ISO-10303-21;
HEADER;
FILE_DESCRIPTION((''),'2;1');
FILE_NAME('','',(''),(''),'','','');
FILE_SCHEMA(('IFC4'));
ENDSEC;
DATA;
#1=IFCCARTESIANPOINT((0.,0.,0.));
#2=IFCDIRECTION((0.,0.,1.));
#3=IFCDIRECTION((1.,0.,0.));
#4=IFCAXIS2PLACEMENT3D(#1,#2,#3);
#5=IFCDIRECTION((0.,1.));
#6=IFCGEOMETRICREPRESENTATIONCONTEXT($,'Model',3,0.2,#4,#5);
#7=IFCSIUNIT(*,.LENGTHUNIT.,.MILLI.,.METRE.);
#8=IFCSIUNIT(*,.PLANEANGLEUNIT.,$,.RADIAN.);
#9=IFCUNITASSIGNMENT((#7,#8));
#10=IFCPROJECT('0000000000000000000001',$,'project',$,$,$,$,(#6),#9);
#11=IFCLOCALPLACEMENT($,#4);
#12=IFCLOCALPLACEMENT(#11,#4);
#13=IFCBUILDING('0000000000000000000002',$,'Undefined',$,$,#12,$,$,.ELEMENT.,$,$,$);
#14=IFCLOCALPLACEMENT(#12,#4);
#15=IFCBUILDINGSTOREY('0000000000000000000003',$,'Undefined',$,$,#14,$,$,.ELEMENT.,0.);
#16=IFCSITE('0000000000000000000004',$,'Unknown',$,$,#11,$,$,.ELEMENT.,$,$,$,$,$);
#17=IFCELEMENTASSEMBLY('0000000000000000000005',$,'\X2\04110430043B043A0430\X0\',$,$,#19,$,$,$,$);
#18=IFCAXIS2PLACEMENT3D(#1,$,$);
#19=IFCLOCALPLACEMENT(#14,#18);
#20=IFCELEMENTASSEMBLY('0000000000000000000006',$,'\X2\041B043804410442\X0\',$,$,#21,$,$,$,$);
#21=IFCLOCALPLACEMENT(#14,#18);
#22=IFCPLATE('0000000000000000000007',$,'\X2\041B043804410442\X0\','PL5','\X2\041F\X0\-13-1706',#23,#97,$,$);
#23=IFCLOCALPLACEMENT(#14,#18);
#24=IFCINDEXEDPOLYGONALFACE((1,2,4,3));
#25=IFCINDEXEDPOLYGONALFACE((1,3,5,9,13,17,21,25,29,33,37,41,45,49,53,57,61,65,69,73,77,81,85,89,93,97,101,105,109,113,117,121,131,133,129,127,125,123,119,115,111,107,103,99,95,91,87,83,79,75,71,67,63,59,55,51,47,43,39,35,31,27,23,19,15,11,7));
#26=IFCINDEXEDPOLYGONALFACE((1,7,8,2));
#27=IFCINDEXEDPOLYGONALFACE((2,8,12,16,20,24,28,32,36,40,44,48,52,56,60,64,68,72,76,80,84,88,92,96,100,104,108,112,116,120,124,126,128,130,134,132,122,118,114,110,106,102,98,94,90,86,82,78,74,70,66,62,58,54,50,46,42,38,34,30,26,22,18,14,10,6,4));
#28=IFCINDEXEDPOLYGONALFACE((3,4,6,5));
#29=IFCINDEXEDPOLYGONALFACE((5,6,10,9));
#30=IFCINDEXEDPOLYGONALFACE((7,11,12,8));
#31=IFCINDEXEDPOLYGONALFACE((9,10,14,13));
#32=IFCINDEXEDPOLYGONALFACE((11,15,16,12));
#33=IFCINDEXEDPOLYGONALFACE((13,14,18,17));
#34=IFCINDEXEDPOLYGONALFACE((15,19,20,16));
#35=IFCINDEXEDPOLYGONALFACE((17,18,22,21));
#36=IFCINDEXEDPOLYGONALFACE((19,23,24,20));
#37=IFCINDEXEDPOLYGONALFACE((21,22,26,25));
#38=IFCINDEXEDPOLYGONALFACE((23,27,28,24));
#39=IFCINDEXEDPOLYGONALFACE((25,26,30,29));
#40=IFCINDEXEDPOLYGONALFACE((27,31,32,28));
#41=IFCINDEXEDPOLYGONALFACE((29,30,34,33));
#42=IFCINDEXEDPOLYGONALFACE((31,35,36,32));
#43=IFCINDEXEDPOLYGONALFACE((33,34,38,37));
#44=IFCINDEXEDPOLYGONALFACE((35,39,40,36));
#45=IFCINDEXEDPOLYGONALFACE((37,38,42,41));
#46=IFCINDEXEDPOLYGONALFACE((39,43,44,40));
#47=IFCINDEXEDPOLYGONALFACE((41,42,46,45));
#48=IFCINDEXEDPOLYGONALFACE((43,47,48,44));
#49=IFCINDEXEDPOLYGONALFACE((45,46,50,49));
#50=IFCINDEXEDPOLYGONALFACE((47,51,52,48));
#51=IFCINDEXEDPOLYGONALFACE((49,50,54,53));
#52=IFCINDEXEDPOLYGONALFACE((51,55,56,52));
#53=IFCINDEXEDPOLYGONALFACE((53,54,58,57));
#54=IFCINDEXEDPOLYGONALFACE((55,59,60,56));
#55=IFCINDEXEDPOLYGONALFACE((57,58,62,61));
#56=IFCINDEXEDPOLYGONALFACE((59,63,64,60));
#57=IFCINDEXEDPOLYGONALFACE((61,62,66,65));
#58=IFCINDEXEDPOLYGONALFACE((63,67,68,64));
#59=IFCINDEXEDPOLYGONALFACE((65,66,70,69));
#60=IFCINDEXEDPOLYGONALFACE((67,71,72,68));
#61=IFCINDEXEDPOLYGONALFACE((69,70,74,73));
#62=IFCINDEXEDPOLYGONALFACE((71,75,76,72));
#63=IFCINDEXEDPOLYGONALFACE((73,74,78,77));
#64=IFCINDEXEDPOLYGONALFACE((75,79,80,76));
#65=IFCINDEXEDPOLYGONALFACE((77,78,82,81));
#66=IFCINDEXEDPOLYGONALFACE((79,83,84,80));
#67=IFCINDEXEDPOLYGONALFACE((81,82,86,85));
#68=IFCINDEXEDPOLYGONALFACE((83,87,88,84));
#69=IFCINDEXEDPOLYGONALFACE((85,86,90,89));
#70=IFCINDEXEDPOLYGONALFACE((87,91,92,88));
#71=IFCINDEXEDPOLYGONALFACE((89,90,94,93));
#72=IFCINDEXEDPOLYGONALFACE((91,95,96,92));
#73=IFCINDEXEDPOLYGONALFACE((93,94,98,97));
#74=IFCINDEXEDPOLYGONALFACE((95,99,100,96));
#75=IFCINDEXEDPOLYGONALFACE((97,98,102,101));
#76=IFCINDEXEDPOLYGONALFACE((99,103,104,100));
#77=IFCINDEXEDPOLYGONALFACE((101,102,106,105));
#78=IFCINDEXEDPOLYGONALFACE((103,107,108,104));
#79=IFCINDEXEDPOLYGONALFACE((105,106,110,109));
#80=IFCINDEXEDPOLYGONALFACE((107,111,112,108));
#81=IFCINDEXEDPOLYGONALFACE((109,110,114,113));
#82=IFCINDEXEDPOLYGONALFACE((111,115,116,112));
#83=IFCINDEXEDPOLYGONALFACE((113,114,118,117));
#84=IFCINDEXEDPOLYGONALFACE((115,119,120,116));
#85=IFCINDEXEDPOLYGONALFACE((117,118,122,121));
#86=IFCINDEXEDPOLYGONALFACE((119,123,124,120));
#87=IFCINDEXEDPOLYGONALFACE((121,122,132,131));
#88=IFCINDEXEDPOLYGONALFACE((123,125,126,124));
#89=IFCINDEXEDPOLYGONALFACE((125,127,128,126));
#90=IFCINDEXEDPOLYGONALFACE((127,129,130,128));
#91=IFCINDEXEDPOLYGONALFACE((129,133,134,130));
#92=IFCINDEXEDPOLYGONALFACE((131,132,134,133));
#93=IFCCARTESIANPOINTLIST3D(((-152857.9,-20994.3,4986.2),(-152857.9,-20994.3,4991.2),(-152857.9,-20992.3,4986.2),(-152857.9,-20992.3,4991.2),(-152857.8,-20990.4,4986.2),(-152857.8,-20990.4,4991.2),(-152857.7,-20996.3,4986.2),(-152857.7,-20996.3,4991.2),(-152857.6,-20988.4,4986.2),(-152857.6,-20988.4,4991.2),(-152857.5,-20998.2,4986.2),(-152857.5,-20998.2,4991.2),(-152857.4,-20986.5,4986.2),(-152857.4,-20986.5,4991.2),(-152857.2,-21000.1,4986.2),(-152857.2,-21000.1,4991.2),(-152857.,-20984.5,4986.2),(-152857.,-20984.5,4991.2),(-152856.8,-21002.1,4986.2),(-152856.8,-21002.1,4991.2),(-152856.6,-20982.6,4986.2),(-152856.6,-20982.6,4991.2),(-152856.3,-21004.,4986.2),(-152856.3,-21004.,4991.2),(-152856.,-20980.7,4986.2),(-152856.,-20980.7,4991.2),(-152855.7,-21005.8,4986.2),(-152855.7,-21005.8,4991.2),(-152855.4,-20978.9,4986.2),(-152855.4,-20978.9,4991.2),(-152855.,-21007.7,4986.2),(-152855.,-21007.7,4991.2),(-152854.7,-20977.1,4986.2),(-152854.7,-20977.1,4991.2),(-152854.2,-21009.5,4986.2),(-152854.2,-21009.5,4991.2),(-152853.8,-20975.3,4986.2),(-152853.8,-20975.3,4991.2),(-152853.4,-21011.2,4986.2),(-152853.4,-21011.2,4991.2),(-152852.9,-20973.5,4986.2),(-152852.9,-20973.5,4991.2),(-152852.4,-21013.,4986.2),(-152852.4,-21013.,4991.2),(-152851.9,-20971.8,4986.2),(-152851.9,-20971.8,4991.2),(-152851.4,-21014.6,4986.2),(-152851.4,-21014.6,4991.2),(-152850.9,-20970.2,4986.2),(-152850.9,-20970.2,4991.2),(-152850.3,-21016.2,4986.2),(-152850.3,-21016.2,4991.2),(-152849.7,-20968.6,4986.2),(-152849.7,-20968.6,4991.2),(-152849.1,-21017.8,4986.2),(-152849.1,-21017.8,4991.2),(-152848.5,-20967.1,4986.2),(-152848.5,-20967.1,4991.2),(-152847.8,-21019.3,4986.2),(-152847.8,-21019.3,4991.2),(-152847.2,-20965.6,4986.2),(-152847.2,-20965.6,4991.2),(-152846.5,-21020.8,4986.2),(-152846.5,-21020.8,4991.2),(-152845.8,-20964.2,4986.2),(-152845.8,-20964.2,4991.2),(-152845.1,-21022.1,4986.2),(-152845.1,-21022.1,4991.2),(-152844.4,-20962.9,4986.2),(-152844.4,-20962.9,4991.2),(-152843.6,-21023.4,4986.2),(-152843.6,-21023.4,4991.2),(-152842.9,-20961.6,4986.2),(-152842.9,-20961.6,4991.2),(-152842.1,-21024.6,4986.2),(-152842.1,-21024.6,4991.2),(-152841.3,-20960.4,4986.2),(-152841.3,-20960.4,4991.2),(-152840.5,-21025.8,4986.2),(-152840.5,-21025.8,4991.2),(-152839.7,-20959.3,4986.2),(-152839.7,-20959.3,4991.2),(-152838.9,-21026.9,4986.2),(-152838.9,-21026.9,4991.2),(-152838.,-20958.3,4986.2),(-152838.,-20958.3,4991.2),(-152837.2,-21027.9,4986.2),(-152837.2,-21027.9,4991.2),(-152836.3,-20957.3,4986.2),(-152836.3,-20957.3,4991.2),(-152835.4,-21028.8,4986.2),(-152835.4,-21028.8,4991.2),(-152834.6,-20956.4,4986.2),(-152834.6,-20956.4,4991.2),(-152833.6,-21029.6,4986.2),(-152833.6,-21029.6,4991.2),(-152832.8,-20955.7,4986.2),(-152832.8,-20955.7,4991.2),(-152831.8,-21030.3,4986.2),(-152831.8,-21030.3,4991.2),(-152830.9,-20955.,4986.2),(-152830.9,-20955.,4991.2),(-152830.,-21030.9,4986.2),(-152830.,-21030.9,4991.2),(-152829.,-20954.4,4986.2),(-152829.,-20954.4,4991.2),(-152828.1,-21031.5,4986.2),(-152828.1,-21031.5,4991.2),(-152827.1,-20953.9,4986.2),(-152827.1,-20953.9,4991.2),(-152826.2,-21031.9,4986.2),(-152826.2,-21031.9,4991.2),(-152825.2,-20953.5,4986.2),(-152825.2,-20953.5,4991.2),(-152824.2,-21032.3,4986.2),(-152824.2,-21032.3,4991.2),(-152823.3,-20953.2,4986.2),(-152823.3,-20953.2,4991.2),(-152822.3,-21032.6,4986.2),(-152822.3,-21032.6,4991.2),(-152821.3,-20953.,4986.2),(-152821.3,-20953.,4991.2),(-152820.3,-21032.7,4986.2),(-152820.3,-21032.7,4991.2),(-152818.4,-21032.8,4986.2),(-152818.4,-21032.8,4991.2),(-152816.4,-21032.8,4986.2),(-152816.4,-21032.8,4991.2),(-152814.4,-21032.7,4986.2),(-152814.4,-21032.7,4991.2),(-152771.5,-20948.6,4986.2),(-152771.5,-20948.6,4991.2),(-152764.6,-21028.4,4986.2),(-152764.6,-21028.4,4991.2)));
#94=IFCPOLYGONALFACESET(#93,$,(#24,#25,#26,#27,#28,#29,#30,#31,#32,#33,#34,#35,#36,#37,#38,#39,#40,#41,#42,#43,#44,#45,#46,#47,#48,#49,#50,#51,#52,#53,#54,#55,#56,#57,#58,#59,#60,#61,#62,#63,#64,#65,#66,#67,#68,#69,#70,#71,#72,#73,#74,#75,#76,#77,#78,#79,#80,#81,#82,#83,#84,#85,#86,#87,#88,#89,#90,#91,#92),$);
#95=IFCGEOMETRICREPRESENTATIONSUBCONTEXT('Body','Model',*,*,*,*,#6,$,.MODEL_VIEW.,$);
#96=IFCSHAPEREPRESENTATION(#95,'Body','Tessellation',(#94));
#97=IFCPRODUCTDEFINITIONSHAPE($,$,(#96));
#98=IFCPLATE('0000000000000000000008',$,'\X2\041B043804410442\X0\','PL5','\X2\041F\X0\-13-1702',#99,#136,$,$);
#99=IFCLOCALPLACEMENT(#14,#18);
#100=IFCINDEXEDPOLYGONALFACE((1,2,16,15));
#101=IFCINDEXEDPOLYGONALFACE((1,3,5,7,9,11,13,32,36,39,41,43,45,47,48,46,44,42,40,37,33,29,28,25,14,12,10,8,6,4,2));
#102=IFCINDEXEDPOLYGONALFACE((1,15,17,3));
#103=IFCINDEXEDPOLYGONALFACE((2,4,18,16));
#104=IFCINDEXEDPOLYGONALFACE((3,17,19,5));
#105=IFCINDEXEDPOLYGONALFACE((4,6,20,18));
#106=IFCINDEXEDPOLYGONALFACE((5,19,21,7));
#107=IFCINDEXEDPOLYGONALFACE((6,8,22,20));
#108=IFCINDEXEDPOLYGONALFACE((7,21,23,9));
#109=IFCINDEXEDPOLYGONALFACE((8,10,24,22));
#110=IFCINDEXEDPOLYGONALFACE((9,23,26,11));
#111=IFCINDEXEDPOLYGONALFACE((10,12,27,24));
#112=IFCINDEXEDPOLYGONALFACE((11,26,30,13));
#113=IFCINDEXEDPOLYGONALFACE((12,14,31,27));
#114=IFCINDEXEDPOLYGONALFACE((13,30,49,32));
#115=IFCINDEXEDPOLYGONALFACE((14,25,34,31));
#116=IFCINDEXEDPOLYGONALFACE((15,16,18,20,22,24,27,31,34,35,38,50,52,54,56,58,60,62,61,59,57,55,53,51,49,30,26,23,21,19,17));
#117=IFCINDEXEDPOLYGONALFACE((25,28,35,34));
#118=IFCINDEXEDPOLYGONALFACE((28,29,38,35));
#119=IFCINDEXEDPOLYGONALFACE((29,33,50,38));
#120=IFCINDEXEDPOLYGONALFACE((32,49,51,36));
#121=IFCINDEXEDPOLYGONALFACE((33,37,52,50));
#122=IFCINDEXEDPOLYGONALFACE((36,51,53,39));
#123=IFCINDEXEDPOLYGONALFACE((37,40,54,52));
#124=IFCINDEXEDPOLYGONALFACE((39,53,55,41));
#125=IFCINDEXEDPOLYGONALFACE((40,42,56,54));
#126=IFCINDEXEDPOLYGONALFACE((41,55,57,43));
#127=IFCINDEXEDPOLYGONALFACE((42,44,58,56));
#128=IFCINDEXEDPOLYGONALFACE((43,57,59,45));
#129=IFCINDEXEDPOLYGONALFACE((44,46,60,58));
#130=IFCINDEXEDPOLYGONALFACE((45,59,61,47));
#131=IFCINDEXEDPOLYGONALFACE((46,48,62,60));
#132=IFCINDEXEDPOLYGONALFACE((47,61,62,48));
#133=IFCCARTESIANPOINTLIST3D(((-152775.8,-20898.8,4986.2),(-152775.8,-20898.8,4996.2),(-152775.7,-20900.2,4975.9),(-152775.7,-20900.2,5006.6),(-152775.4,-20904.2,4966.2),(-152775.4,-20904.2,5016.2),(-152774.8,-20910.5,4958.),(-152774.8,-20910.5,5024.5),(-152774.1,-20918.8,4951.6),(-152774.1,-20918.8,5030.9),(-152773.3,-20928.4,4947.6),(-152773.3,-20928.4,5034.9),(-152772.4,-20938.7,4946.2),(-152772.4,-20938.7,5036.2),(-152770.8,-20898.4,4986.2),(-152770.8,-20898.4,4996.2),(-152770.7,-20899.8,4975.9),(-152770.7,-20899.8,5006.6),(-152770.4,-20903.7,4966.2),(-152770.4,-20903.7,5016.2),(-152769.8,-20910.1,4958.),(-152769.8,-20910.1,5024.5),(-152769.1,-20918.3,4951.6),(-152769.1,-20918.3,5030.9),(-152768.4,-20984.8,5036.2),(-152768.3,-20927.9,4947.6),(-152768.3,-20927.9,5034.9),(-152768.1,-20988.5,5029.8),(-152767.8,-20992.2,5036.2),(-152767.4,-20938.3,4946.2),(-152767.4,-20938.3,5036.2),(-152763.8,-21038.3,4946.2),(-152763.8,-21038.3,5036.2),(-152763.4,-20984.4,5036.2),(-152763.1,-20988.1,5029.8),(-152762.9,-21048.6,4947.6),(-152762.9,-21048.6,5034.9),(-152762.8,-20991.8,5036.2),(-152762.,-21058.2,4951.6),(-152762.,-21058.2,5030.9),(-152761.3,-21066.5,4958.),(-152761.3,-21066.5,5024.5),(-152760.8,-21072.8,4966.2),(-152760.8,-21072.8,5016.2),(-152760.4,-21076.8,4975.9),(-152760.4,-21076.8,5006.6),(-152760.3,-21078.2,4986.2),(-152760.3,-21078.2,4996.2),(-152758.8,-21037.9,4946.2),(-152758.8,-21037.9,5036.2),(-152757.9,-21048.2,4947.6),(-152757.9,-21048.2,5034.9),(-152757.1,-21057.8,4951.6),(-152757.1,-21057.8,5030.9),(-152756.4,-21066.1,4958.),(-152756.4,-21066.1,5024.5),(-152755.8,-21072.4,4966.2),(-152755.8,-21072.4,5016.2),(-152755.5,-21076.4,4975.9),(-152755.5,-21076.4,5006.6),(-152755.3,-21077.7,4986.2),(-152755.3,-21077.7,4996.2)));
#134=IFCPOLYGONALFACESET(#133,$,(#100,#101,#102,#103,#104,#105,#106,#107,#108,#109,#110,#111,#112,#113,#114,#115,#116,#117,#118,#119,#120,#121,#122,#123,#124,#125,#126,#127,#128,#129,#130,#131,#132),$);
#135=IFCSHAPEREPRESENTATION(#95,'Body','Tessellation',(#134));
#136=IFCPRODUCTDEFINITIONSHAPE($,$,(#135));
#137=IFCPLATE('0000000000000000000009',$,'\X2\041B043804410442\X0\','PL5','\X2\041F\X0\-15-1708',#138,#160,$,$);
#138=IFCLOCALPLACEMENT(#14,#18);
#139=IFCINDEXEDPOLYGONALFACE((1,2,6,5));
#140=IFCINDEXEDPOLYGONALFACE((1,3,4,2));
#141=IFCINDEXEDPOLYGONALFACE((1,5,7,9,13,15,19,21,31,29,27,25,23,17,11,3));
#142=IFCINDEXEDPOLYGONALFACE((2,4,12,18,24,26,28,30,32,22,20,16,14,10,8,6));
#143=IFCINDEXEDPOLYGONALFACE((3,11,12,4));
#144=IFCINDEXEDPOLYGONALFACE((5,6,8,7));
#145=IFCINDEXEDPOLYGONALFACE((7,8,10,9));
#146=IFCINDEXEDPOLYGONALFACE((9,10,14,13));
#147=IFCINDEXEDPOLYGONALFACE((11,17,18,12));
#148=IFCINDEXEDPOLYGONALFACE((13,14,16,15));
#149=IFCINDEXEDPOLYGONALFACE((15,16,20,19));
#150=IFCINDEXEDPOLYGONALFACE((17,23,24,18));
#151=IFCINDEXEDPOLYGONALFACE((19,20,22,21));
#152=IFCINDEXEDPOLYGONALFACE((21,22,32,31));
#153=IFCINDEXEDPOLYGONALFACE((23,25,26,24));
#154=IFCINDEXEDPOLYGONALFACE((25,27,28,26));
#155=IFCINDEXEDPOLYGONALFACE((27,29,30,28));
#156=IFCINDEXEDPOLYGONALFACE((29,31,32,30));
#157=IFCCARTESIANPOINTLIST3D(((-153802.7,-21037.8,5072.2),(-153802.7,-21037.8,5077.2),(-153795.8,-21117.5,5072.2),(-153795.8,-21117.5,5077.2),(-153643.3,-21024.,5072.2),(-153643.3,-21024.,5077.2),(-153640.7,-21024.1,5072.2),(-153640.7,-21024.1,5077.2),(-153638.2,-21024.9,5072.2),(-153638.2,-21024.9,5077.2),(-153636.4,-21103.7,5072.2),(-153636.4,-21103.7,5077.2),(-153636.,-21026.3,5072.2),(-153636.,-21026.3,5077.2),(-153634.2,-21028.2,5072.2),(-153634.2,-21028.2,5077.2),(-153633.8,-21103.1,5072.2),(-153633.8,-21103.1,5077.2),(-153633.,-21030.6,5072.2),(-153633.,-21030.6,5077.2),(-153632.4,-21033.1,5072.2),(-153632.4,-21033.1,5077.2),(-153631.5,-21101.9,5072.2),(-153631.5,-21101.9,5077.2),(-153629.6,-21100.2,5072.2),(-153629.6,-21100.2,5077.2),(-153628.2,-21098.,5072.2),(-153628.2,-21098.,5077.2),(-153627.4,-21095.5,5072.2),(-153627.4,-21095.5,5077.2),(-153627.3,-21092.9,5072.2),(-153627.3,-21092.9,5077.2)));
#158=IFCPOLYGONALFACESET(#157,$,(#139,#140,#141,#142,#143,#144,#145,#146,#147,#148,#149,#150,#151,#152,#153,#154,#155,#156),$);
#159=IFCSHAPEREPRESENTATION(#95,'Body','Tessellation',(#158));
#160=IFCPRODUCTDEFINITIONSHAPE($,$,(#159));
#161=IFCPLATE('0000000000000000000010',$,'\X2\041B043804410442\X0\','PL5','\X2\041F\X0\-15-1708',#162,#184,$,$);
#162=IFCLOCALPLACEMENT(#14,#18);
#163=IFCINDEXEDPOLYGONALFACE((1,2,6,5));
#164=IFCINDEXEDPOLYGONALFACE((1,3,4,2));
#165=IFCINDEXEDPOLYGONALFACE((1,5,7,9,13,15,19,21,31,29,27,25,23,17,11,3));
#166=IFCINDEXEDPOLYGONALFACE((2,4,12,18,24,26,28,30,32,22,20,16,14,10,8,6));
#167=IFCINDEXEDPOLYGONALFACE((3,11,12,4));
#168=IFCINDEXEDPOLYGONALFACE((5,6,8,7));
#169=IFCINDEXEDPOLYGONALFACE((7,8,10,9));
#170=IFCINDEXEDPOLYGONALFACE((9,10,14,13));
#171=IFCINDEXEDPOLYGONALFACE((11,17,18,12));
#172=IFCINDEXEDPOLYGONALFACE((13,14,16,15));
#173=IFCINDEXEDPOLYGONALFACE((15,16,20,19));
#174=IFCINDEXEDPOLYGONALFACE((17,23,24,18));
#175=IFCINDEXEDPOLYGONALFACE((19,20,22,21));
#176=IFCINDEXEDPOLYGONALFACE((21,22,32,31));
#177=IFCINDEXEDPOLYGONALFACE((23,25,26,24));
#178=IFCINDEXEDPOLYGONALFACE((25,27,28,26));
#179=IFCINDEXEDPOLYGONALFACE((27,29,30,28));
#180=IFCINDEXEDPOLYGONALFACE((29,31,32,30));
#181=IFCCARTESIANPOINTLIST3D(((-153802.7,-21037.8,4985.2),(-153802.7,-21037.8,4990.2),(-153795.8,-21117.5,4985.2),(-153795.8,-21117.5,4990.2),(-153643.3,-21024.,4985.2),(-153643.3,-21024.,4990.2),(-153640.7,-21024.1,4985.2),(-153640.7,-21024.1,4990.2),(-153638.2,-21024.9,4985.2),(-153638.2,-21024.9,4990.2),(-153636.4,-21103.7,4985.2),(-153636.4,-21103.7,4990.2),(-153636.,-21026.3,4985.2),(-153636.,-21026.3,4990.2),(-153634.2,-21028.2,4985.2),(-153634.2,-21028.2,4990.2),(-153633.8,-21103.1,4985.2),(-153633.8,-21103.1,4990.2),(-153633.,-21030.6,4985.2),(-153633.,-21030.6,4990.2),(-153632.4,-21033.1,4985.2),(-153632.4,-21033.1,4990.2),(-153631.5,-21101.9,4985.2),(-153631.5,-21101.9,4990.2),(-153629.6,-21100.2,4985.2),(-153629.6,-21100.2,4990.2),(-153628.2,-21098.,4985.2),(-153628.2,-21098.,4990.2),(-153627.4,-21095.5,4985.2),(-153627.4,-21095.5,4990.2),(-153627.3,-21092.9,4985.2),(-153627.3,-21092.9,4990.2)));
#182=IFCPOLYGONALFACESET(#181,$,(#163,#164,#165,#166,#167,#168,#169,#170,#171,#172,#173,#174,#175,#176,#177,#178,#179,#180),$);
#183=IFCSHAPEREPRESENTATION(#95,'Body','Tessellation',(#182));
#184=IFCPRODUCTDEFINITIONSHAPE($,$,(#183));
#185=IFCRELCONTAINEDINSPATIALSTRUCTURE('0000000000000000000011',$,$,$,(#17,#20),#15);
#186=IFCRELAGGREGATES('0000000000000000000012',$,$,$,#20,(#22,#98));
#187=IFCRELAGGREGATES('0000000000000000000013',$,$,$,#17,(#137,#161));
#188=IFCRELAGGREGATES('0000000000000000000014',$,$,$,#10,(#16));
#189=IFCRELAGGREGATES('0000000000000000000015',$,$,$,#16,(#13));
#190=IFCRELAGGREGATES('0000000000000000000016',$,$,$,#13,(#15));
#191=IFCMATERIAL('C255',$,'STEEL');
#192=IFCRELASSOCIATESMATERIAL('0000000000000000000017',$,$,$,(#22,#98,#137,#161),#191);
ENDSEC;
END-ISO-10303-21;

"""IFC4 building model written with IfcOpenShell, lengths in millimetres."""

from ifc_helpers import new_model, si_unit, direction, frame, origin_with_axes, place, context, subcontext, project, spatial, line, arc, indexed_curve, outline, extrude, material, element, aggregate, save


model = new_model("IFC4")

# Units and contexts
model_context = context("Model", 3, precision=0.2, world=origin_with_axes(), true_north=direction((0.0, 1.0)))
body_context = subcontext(model_context, "Body", "Model", "MODEL_VIEW")
ifc_project = project(units=[si_unit("LENGTHUNIT", "METRE", prefix="MILLI"), si_unit("PLANEANGLEUNIT", "RADIAN")], contexts=[model_context])

# Site, building, storey
site_placement = place(None, origin_with_axes())
site = spatial("IfcSite", under=ifc_project, at=site_placement, Name="Unknown", CompositionType="ELEMENT")
building_placement = place(site_placement, origin_with_axes())
building = spatial("IfcBuilding", under=site, at=building_placement, Name="Undefined", CompositionType="ELEMENT")
storey_placement = place(building_placement, origin_with_axes())
storey = spatial("IfcBuildingStorey", under=building, at=storey_placement, Name="Undefined", CompositionType="ELEMENT", Elevation=0.0)

# Element assembly
ifc_material_1 = material(Name="C255", Category="STEEL")
assembly_1_placement = place(storey_placement, frame((-153801.7, -21077.8, 5121.2), z_axis=(0.996285, 0.086114, 0.0), x_axis=(0.0, 0.0, -1.0)))
assembly_1 = element("IfcElementAssembly", 1, at=assembly_1_placement, inside=storey, Name="Балка")

# Element assembly, plates, voiding feature
assembly_2_placement = place(storey_placement, frame((-152757.8, -21078.0, 4946.2), z_axis=(-0.996285, -0.086114, 0.0), x_axis=(0.0, 0.0, 1.0)))
assembly_2 = element("IfcElementAssembly", 2, at=assembly_2_placement, inside=storey, Name="Лист")
plate_1_placement = place(assembly_2_placement, frame((42.5, 50.0, 2.5), z_axis=(1.0, 0.0, 0.0), x_axis=(0.0, 1.0, 0.0)))
plate_1 = element("IfcPlate", 3, at=plate_1_placement, material=ifc_material_1, Name="Лист", Description="PL5", ObjectType="П-13-1706", context=body_context, shape_type="SolidModel", body=[
    extrude(outline(indexed_curve([(0.0, 0.0), (80.0, 0.0), (80.0, 50.0), (80.0, 52.0), (79.8, 53.9), (79.6, 55.9), (79.2, 57.8), (78.8, 59.7), (78.3, 61.6), (77.7, 63.5), (77.0, 65.3), (76.2, 67.1), (75.3, 68.9), (74.3, 70.6), (73.3, 72.2), (72.1, 73.8), (70.9, 75.4), (69.6, 76.9), (68.3, 78.3), (66.9, 79.6), (65.4, 80.9), (63.8, 82.1), (62.2, 83.3), (60.6, 84.3), (58.9, 85.3), (57.1, 86.2), (55.3, 87.0), (53.5, 87.7), (51.6, 88.3), (49.7, 88.8), (47.8, 89.2), (45.9, 89.6), (43.9, 89.8), (42.0, 90.0), (40.0, 90.0), (40.0, 90.0), (38.0, 90.0), (36.1, 89.8), (34.1, 89.6), (32.2, 89.2), (30.3, 88.8), (28.4, 88.3), (26.5, 87.7), (24.7, 87.0), (22.9, 86.2), (21.1, 85.3), (19.4, 84.3), (17.8, 83.3), (16.2, 82.1), (14.6, 80.9), (13.1, 79.6), (11.7, 78.3), (10.4, 76.9), (9.1, 75.4), (7.9, 73.8), (6.7, 72.2), (5.7, 70.6), (4.7, 68.9), (3.8, 67.1), (3.0, 65.3), (2.3, 63.5), (1.7, 61.6), (1.2, 59.7), (0.8, 57.8), (0.4, 55.9), (0.2, 53.9), (0.0, 52.0), (0.0, 50.0)], segments=[line(1, 2, 3, 4, 5, 6, 7, 8, 9, 10, 11, 12, 13, 14, 15, 16, 17, 18, 19, 20, 21, 22, 23, 24, 25, 26, 27, 28, 29, 30, 31, 32, 33, 34, 35, 36, 37, 38, 39, 40, 41, 42, 43, 44, 45, 46, 47, 48, 49, 50, 51, 52, 53, 54, 55, 56, 57, 58, 59, 60, 61, 62, 63, 64, 65, 66, 67, 68, 1)])), frame((0.0, 0.0, 2.5), z_axis=(0.0, 0.0, 1.0), x_axis=(1.0, 0.0, 0.0)), (0.0, 0.0, -1.0), 5.0),
])
plate_2_placement = place(assembly_2_placement, origin_with_axes())
plate_2 = element("IfcPlate", 4, at=plate_2_placement, material=ifc_material_1, Name="Лист", Description="PL5", ObjectType="П-13-1702", context=body_context, shape_type="SolidModel", body=[
    extrude(outline(indexed_curve([(0.0, 40.0), (11.7, 11.7), (40.0, 0.0), (50.0, 0.0), (78.3, 11.7), (90.0, 40.0), (90.0, 140.0), (78.3, 168.3), (50.0, 180.0), (40.0, 180.0), (11.7, 168.3), (0.0, 140.0)], segments=[arc(1, 2, 3), line(3, 4), arc(4, 5, 6), line(6, 7), arc(7, 8, 9), line(9, 10), arc(10, 11, 12), line(12, 1)])), frame((0.0, 0.0, 2.5), z_axis=(0.0, 0.0, 1.0), x_axis=(1.0, 0.0, 0.0)), (0.0, 0.0, -1.0), 5.0),
])
voiding_feature_1_placement = place(plate_2_placement, frame((90.5, 90.0, -3.5), z_axis=(-1.0, -0.000054, 0.0), x_axis=(0.0, 0.0, 1.0)))
element("IfcVoidingFeature", 5, at=voiding_feature_1_placement, cuts=plate_2, Name="Связь вертикальная", ObjectType="(?)", PredefinedType="HOLE", context=body_context, shape_type="SolidModel", body=[
    extrude(outline(indexed_curve([(0.0, -4.0), (6.9, 0.0), (0.0, 4.0)], segments=[line(1, 2, 3, 1)])), frame((0.0, 0.0, 0.0), z_axis=(-1.0, 0.0, 0.0), x_axis=(0.0, 0.0, 1.0)), (0.0, 0.0, -1.0), 7.0),
])

# Plates
plate_3_placement = place(assembly_1_placement, frame((46.5, 40.0, 2.5), z_axis=(-1.0, 0.0, 0.0), x_axis=(0.0, -1.0, 0.0)))
plate_3 = element("IfcPlate", 6, at=plate_3_placement, material=ifc_material_1, Name="Лист", Description="PL5", ObjectType="П-15-1708", context=body_context, shape_type="SolidModel", body=[
    extrude(outline(indexed_curve([(0.0, 0.0), (80.0, 0.0), (80.0, 160.0), (77.1, 167.1), (70.0, 170.0), (10.0, 170.0), (2.9, 167.1), (0.0, 160.0)], segments=[line(1, 2, 3), arc(3, 4, 5), line(5, 6), arc(6, 7, 8), line(8, 1)])), frame((0.0, 0.0, 2.5), z_axis=(0.0, 0.0, 1.0), x_axis=(1.0, 0.0, 0.0)), (0.0, 0.0, -1.0), 5.0),
])
plate_4_placement = place(assembly_1_placement, frame((133.5, 40.0, 2.5), z_axis=(-1.0, 0.0, 0.0), x_axis=(0.0, -1.0, 0.0)))
plate_4 = element("IfcPlate", 7, at=plate_4_placement, material=ifc_material_1, Name="Лист", Description="PL5", ObjectType="П-15-1708", context=body_context, shape_type="SolidModel", body=[
    extrude(outline(indexed_curve([(0.0, 0.0), (80.0, 0.0), (80.0, 160.0), (77.1, 167.1), (70.0, 170.0), (10.0, 170.0), (2.9, 167.1), (0.0, 160.0)], segments=[line(1, 2, 3), arc(3, 4, 5), line(5, 6), arc(6, 7, 8), line(8, 1)])), frame((0.0, 0.0, 2.5), z_axis=(0.0, 0.0, 1.0), x_axis=(1.0, 0.0, 0.0)), (0.0, 0.0, -1.0), 5.0),
])

aggregate(assembly_2, [plate_1, plate_2])
aggregate(assembly_1, [plate_3, plate_4])

save(model, "model.ifc")
